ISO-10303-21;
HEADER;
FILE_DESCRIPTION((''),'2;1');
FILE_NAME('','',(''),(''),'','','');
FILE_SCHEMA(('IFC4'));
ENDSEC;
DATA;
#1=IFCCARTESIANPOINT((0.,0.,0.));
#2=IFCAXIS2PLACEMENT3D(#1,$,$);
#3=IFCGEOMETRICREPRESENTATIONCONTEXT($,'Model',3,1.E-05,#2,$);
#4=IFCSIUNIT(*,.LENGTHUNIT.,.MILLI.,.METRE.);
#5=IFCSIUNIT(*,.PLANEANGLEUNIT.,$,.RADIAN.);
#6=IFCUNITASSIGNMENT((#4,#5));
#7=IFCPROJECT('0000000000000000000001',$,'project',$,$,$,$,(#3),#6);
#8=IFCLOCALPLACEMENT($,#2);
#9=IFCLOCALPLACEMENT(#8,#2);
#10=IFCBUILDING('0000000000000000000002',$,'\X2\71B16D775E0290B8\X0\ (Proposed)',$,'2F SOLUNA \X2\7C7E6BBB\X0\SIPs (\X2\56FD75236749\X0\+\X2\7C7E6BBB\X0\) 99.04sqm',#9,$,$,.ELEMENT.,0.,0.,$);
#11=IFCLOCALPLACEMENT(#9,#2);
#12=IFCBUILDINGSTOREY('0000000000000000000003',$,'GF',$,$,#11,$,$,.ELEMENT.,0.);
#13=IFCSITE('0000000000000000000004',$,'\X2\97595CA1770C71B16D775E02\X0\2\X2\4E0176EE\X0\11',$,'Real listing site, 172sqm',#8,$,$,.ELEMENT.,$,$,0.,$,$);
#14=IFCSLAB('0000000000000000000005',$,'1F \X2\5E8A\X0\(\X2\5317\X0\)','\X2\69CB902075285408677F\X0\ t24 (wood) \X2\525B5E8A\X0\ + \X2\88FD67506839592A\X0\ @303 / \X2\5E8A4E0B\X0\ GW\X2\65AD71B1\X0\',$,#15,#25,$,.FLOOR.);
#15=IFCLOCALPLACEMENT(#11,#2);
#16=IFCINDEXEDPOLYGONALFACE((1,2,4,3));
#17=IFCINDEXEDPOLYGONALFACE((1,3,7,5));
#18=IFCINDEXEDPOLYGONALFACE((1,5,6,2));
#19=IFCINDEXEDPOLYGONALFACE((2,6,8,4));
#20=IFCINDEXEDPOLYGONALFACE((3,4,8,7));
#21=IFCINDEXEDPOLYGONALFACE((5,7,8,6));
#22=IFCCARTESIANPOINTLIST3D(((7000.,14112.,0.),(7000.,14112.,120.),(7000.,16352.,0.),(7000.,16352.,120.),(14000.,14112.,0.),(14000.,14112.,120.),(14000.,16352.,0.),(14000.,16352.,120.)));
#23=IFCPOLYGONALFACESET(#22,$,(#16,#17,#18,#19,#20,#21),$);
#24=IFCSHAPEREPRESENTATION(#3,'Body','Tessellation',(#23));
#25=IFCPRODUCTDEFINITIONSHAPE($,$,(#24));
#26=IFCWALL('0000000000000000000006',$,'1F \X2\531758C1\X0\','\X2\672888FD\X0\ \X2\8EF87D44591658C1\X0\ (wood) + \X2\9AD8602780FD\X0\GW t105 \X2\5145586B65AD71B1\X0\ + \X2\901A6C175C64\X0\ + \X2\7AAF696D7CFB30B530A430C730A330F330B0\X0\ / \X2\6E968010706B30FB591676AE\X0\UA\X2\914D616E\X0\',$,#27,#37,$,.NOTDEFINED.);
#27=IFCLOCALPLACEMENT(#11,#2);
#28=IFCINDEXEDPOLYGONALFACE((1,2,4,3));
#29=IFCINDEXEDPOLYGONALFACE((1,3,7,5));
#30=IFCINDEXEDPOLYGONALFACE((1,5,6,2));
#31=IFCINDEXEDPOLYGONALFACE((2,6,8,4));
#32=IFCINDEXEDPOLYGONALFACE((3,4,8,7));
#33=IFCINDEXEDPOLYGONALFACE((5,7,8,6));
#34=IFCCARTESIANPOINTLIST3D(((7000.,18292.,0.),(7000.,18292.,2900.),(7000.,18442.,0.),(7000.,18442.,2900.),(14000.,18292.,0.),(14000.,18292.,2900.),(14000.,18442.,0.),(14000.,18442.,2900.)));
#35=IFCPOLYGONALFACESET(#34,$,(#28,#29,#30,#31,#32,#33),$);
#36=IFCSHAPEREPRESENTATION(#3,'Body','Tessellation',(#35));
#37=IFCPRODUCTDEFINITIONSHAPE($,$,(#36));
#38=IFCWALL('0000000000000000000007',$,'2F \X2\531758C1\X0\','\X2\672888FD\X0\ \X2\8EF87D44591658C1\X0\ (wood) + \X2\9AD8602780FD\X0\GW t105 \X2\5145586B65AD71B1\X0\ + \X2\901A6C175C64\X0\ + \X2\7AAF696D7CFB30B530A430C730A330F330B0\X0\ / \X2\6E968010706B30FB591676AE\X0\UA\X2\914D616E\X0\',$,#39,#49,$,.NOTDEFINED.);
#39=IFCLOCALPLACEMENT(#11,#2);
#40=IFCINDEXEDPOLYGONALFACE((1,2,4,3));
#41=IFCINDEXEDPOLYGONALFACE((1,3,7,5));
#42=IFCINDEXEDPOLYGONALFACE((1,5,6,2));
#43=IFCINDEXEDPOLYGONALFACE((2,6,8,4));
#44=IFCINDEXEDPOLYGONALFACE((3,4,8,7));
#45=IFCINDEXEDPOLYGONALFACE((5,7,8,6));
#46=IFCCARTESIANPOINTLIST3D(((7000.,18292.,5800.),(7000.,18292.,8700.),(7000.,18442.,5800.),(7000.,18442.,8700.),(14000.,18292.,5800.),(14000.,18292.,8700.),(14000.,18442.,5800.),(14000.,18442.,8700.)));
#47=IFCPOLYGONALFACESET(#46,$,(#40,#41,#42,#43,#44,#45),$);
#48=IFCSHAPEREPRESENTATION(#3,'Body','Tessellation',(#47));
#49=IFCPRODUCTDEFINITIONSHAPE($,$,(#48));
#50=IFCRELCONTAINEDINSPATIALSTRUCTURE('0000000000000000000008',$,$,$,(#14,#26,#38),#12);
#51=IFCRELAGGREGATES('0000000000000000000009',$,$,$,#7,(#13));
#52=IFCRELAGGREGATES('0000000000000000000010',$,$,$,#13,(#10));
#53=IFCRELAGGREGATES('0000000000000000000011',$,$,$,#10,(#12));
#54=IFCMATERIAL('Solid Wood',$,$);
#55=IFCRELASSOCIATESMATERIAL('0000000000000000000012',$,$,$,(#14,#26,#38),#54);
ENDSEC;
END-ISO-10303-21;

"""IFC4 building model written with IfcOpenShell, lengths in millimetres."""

from ifc_helpers import new_model, si_unit, frame, frame_2d, origin, place, context, project, spatial, rectangle, extrude, material, element, save


model = new_model("IFC4")

# Units and contexts
model_context = context("Model", 3, precision=1e-05, world=origin())
ifc_project = project(units=[si_unit("LENGTHUNIT", "METRE", prefix="MILLI"), si_unit("PLANEANGLEUNIT", "RADIAN")], contexts=[model_context])

# Site, building, storey
site_placement = place(None, origin())
site = spatial("IfcSite", under=ifc_project, at=site_placement, Name="静岡県熱海市2丁目11", ObjectType="Real listing site, 172sqm", CompositionType="ELEMENT", RefElevation=0.0)
building_placement = place(site_placement, origin())
building = spatial("IfcBuilding", under=site, at=building_placement, Name="熱海市邸 (Proposed)", ObjectType="2F SOLUNA 籾殻SIPs (国産杉+籾殻) 99.04sqm", CompositionType="ELEMENT", ElevationOfRefHeight=0.0, ElevationOfTerrain=0.0)
storey_placement = place(building_placement, origin())
storey = spatial("IfcBuildingStorey", under=building, at=storey_placement, Name="GF", CompositionType="ELEMENT", Elevation=0.0)

# Slab
ifc_material_1 = material(Name="Solid Wood")
slab_1_placement = place(storey_placement, frame((3500.0, 7056.0, 0.0)))
element("IfcSlab", 1, at=slab_1_placement, inside=storey, material=ifc_material_1, Name="1F 床(北)", Description="構造用合板 t24 (wood) 剛床 + 製材根太 @303 / 床下 GW断熱", PredefinedType="FLOOR", context=model_context, shape_type="SweptSolid", body=[
    extrude(rectangle(XDim=7000.0, YDim=2240.0, at=frame_2d((3500.0, 1120.0))), frame((3500.0, 7056.0, 0.0)), (0.0, 0.0, 1.0), 120.0),
])

# Wall
wall_1_placement = place(storey_placement, frame((3500.0, 9146.0, 0.0)))
element("IfcWall", 2, at=wall_1_placement, inside=storey, material=ifc_material_1, Name="1F 北壁", Description="木製 軸組外壁 (wood) + 高性能GW t105 充填断熱 + 通気層 + 窯業系サイディング / 準耐火・外皮UA配慮", PredefinedType="NOTDEFINED", context=model_context, shape_type="SweptSolid", body=[
    extrude(rectangle(XDim=7000.0, YDim=150.0, at=frame_2d((3500.0, 75.0))), frame((3500.0, 9146.0, 0.0)), (0.0, 0.0, 1.0), 2900.0),
])

# Wall
wall_2_placement = place(storey_placement, frame((3500.0, 9146.0, 2900.0)))
element("IfcWall", 3, at=wall_2_placement, inside=storey, material=ifc_material_1, Name="2F 北壁", Description="木製 軸組外壁 (wood) + 高性能GW t105 充填断熱 + 通気層 + 窯業系サイディング / 準耐火・外皮UA配慮", PredefinedType="NOTDEFINED", context=model_context, shape_type="SweptSolid", body=[
    extrude(rectangle(XDim=7000.0, YDim=150.0, at=frame_2d((3500.0, 75.0))), frame((3500.0, 9146.0, 2900.0)), (0.0, 0.0, 1.0), 2900.0),
])

save(model, "model.ifc")
